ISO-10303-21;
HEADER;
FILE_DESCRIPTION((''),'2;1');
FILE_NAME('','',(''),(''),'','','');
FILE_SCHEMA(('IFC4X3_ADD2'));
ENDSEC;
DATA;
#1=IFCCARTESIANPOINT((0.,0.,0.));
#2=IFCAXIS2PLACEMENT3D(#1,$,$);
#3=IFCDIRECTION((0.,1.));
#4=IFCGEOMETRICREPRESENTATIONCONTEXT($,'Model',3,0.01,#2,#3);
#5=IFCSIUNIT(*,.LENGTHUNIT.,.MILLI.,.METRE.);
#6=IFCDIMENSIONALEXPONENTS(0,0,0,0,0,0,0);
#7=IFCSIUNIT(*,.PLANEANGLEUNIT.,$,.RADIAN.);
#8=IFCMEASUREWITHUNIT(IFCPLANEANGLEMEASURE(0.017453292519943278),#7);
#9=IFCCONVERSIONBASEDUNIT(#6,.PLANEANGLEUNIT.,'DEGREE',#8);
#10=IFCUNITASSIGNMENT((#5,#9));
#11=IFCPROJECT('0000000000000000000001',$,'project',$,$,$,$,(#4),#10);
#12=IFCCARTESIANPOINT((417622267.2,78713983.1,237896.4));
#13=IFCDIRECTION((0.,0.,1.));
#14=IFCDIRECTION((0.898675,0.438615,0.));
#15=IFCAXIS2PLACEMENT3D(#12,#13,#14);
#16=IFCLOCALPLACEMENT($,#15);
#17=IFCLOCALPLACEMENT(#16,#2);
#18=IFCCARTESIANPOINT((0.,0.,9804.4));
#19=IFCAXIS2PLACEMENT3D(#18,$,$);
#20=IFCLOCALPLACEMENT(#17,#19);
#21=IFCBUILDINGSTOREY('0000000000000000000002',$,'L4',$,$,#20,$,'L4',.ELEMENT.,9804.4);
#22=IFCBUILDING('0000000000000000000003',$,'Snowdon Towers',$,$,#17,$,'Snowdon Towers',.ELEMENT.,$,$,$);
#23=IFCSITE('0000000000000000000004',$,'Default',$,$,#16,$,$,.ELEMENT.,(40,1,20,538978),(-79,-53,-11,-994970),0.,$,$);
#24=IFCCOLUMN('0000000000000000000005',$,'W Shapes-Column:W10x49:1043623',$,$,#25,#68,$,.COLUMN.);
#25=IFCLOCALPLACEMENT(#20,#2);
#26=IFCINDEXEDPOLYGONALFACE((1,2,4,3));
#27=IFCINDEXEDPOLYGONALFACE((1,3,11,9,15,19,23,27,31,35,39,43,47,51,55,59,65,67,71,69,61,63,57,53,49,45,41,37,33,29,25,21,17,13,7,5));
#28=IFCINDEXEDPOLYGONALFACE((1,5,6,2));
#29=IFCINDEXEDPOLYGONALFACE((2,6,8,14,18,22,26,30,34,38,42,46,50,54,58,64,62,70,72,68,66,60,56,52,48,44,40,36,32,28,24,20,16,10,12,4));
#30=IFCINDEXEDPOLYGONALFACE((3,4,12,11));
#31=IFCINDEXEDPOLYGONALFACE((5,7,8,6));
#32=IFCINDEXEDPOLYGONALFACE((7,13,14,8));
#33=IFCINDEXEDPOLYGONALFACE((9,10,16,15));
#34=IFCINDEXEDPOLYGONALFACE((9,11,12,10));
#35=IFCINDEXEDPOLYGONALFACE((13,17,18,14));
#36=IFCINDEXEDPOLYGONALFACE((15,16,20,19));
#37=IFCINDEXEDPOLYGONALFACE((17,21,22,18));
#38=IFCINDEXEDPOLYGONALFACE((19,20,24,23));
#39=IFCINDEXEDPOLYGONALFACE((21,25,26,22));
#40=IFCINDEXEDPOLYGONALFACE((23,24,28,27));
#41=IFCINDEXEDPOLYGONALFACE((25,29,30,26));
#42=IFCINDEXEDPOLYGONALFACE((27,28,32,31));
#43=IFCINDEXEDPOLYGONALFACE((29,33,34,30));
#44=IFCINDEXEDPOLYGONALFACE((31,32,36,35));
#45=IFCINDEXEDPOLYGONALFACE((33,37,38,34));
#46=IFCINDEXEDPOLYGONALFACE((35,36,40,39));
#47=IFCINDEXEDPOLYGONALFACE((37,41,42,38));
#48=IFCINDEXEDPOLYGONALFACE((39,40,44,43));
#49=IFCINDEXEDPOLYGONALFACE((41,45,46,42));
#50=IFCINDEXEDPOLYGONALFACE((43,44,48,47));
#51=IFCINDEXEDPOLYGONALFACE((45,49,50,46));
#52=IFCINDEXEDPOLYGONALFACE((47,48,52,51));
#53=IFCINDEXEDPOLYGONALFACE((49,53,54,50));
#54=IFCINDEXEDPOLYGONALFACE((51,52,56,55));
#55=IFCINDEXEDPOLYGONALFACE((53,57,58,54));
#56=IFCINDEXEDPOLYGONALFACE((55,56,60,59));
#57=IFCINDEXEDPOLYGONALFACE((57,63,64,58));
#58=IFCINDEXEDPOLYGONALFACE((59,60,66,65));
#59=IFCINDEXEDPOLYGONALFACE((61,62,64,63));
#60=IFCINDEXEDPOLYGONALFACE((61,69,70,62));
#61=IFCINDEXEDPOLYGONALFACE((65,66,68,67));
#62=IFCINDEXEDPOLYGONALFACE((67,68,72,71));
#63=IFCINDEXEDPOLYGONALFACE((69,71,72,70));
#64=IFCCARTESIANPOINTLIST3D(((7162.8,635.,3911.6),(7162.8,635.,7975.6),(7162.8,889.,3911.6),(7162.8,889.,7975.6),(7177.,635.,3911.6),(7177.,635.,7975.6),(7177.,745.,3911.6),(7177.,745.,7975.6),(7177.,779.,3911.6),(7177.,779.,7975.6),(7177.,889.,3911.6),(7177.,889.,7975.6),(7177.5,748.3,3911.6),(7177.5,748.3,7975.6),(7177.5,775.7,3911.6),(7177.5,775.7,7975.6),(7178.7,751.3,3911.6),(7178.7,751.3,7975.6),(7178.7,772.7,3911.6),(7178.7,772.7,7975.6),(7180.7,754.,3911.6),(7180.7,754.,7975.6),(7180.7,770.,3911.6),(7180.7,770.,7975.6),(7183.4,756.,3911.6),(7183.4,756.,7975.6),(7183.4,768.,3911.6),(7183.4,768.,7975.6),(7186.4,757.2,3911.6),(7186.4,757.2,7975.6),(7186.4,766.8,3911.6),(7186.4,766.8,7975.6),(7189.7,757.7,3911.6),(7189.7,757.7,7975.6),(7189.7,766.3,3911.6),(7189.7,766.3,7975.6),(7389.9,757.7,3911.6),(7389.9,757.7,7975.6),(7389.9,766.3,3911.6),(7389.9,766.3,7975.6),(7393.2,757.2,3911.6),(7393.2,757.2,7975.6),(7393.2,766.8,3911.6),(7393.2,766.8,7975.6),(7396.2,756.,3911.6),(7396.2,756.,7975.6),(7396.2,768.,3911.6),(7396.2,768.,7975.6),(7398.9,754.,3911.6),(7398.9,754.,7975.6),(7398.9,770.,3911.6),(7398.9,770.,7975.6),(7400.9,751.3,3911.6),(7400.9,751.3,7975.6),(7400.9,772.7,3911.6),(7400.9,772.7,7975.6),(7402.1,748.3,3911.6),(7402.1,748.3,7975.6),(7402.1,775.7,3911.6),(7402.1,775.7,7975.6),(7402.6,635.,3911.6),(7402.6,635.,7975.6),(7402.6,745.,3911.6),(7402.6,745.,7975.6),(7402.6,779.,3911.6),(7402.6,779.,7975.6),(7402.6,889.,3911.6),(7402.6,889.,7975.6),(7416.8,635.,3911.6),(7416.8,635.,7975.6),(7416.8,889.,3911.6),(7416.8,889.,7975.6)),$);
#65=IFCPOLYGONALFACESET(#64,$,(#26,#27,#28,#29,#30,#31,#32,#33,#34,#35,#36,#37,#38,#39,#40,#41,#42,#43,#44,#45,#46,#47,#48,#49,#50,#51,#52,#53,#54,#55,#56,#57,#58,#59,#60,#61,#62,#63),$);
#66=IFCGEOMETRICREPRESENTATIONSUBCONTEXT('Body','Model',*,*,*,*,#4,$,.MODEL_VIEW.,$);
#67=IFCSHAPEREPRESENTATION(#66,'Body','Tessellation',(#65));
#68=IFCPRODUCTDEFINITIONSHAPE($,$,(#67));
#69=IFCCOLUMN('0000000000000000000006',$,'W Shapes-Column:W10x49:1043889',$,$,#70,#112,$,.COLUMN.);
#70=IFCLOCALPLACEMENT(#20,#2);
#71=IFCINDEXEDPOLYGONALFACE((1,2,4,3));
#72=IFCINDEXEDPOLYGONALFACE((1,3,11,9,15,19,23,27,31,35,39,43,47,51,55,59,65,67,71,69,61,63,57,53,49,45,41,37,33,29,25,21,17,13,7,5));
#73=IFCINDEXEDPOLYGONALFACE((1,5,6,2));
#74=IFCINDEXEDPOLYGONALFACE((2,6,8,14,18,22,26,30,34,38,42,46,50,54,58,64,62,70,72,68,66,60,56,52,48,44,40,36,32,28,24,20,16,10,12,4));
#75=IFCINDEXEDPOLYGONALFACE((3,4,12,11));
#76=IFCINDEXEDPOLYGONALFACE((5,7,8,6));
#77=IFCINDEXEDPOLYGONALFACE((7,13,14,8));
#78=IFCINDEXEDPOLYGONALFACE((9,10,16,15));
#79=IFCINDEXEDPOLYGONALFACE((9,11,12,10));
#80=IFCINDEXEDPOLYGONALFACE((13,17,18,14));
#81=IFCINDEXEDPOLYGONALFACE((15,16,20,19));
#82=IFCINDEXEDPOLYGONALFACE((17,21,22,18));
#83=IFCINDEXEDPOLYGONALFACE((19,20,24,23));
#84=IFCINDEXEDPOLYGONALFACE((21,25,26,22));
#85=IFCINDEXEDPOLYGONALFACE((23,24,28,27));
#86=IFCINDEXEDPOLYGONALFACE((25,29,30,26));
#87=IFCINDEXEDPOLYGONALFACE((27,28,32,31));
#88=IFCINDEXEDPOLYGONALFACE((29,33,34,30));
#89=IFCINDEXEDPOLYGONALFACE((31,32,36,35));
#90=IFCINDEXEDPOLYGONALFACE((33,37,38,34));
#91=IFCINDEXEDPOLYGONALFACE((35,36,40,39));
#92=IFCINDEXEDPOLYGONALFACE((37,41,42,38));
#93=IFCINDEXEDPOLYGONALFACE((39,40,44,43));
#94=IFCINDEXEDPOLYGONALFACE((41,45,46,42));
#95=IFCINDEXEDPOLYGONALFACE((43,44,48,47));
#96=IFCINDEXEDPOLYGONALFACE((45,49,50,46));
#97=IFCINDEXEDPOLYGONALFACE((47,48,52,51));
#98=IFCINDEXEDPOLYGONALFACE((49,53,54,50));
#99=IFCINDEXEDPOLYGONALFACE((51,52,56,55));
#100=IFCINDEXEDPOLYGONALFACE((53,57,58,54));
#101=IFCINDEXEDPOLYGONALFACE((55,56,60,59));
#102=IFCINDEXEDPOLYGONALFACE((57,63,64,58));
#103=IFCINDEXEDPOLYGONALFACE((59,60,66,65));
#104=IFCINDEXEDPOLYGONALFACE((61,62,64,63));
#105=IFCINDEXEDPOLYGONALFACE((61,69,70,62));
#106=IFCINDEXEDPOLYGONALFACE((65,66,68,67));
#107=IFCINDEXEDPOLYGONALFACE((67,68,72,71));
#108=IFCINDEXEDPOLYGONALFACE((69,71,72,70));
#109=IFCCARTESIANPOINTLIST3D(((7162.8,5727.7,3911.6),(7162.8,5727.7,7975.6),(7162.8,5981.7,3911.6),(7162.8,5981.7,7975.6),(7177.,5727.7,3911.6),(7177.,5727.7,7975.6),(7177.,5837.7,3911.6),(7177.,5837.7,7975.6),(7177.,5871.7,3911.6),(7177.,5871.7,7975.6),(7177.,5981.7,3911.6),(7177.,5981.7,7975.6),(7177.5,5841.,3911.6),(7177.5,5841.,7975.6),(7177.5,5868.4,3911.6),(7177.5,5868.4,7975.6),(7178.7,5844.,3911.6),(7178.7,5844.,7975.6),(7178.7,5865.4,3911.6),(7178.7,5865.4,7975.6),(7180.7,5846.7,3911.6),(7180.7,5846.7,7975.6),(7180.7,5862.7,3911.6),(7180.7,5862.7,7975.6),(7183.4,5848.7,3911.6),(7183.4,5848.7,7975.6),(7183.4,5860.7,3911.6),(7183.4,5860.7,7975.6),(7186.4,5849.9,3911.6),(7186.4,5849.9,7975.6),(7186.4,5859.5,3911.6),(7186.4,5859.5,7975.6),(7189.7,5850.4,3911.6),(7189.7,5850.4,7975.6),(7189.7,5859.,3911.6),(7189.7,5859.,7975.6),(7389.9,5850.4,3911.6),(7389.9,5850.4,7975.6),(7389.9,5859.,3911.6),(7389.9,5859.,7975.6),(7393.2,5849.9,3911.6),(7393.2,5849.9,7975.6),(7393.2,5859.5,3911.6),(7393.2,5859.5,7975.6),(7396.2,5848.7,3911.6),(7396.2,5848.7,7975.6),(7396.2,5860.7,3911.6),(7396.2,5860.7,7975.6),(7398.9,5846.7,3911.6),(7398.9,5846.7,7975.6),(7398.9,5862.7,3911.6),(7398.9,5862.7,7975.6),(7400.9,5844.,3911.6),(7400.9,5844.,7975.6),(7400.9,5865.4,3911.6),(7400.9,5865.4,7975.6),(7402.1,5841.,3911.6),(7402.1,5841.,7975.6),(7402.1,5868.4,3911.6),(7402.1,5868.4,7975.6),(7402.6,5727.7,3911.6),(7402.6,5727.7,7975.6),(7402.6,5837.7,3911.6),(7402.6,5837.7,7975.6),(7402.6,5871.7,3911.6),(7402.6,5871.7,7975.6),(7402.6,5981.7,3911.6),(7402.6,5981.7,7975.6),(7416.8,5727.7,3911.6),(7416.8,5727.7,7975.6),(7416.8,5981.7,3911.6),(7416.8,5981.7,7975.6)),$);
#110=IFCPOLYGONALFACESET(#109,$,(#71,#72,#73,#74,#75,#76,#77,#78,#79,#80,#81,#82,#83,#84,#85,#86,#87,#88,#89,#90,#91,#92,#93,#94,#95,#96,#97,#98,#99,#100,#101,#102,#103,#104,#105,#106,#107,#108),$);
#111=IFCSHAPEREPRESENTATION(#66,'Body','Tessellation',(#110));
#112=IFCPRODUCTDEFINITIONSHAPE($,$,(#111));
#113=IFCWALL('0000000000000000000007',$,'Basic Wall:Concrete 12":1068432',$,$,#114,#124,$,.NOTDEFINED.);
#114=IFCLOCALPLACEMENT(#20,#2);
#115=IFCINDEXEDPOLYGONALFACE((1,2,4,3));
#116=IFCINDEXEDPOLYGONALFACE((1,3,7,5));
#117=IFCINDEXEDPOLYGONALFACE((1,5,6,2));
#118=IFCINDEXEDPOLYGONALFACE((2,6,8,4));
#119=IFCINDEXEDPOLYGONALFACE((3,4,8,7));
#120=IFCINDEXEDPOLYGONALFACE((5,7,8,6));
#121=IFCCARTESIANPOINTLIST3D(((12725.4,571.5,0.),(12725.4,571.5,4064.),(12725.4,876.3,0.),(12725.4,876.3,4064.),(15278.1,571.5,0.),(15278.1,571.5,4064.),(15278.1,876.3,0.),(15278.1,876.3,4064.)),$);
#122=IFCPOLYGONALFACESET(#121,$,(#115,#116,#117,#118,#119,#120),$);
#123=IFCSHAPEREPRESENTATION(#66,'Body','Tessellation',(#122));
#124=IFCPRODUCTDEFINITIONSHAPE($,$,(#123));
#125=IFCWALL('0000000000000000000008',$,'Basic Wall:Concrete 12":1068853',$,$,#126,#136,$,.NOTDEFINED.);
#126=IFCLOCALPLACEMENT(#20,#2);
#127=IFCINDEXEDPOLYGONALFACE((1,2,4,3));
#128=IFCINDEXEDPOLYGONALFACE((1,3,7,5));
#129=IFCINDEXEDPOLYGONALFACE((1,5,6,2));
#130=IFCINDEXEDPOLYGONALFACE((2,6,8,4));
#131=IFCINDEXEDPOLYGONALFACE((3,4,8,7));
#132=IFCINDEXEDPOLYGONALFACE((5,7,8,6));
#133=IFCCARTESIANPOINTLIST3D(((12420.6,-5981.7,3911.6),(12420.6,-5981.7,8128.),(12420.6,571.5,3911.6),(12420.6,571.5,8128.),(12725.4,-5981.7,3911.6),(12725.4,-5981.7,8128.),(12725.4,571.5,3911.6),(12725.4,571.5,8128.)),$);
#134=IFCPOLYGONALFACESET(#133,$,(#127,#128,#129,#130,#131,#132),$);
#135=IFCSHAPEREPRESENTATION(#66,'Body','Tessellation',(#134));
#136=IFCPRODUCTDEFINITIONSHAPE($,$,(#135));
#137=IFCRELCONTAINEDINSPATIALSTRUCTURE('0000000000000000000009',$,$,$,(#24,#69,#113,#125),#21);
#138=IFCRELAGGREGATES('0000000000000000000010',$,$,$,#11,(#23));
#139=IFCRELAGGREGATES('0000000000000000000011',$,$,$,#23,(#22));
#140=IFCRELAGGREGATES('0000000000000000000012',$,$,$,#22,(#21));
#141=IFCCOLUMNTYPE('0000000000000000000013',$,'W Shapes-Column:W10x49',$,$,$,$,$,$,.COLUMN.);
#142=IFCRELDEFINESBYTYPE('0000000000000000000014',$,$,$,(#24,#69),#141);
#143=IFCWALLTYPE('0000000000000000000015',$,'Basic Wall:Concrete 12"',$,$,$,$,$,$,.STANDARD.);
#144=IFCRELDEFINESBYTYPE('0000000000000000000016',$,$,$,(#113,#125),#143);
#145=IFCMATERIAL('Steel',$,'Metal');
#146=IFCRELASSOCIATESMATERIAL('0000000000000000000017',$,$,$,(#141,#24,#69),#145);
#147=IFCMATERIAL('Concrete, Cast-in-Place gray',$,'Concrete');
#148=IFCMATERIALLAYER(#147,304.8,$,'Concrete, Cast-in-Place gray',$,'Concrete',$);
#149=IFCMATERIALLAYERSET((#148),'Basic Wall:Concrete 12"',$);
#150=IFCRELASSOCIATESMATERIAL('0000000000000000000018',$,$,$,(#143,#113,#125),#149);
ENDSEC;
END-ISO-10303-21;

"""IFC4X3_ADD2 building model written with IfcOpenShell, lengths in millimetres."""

from ifc_helpers import new_model, entity, si_unit, converted_unit, direction, frame, frame_2d, origin, place, context, subcontext, project, spatial, rectangle, i_section, extrude, source, transform, mapped, material, layer, layer_set, material_profile, profile_set, profile_usage, type_object, type_shapes, element, save


model = new_model("IFC4X3_ADD2")

# Units and contexts
model_context = context("Model", 3, precision=0.01, world=origin(), true_north=direction((0.0, 1.0)))
body_context = subcontext(model_context, "Body", "Model", "MODEL_VIEW")
ifc_project = project(units=[si_unit("LENGTHUNIT", "METRE", prefix="MILLI"), converted_unit("PLANEANGLEUNIT", "DEGREE", entity("IfcPlaneAngleMeasure", 0.017453292519943278), si_unit("PLANEANGLEUNIT", "RADIAN"), dimensions=[0, 0, 0, 0, 0, 0, 0])], contexts=[model_context])

# Site, building, storey
site_placement = place(None, frame((417622267.2, 78713983.1, 237896.4), z_axis=(0.0, 0.0, 1.0), x_axis=(0.898675, 0.438615, 0.0)))
site = spatial("IfcSite", under=ifc_project, at=site_placement, Name="Default", CompositionType="ELEMENT", RefLatitude=(40, 1, 20, 538978), RefLongitude=(-79, -53, -11, -994970), RefElevation=0.0)
building_placement = place(site_placement, origin())
building = spatial("IfcBuilding", under=site, at=building_placement, Name="Snowdon Towers", LongName="Snowdon Towers", CompositionType="ELEMENT")
storey_placement = place(building_placement, frame((0.0, 0.0, 9804.4)))
storey = spatial("IfcBuildingStorey", under=building, at=storey_placement, Name="L4", LongName="L4", CompositionType="ELEMENT", Elevation=9804.4)

# Columns
ifc_material_1 = material(Name="Steel", Category="Metal")
ifc_material_profile_1 = material_profile(ifc_material_1, i_section(OverallWidth=254.0, OverallDepth=254.0, WebThickness=8.6, FlangeThickness=14.2, FilletRadius=12.7, at=frame_2d((0.0, 0.0), x_axis=(1.0, 0.0))), Name="W10x49")
ifc_profile_set_1 = profile_set([ifc_material_profile_1], Name="W10x49")
ifc_profile_usage_1 = profile_usage(ifc_profile_set_1)
column_type_1 = type_object("IfcColumnType", Name="W Shapes-Column:W10x49", PredefinedType="COLUMN", material=ifc_profile_set_1)
shared_shape_1 = source(origin(), body_context, "Body", "SweptSolid", [
    extrude(i_section(OverallWidth=254.0, OverallDepth=254.0, WebThickness=8.6, FlangeThickness=14.2, FilletRadius=12.7, at=frame_2d((0.0, 0.0), x_axis=(1.0, 0.0))), frame((0.0, 0.0, 13716.0), z_axis=(0.0, 0.0, 1.0), x_axis=(-1.0, 0.0, 0.0)), (0.0, 0.0, 1.0), 4064.0),
])
type_shapes(column_type_1, [shared_shape_1])
for number, where, z_axis, x_axis, name in (
    (1, (7289.8, 762.0, -9804.4), (0.0, 0.0, 1.0), (0.0, 1.0, 0.0), "W Shapes-Column:W10x49:1043623"),
    (2, (7289.8, 5854.7, -9804.4), (0.0, 0.0, 1.0), (0.0, 1.0, 0.0), "W Shapes-Column:W10x49:1043889"),
):
    element("IfcColumn", number, at=place(storey_placement, frame(where, z_axis=z_axis, x_axis=x_axis)), inside=storey, type_object=column_type_1, material=ifc_profile_usage_1, Name=name, PredefinedType="COLUMN", context=body_context, shape_type="MappedRepresentation", body=[
        mapped(shared_shape_1, transform((0.0, 0.0, 0.0), scale=1.0)),
    ])

# Walls
ifc_material_2 = material(Name="Concrete, Cast-in-Place gray", Category="Concrete")
ifc_layer = layer(ifc_material_2, 304.8, Name="Concrete, Cast-in-Place gray", Category="Concrete")
ifc_layer_set = layer_set([ifc_layer], Name="Basic Wall:Concrete 12\"")
wall_type = type_object("IfcWallType", Name="Basic Wall:Concrete 12\"", PredefinedType="STANDARD", material=ifc_layer_set)
wall_1_placement = place(storey_placement, frame((15278.1, 723.9, 0.0), z_axis=(0.0, 0.0, 1.0), x_axis=(-1.0, 0.0, 0.0)))
element("IfcWall", 3, at=wall_1_placement, inside=storey, type_object=wall_type, material=ifc_layer_set, Name="Basic Wall:Concrete 12\":1068432", PredefinedType="NOTDEFINED", context=body_context, shape_type="SweptSolid", body=[
    extrude(rectangle(XDim=2552.7, YDim=304.8, at=frame_2d((1276.3, 0.0), x_axis=(-1.0, 0.0))), origin(), (0.0, 0.0, 1.0), 4064.0),
])
wall_2_placement = place(storey_placement, frame((12573.0, 571.5, 3911.6), z_axis=(0.0, 0.0, 1.0), x_axis=(0.0, -1.0, 0.0)))
element("IfcWall", 4, at=wall_2_placement, inside=storey, type_object=wall_type, material=ifc_layer_set, Name="Basic Wall:Concrete 12\":1068853", PredefinedType="NOTDEFINED", context=body_context, shape_type="SweptSolid", body=[
    extrude(rectangle(XDim=6553.2, YDim=304.8, at=frame_2d((3276.6, 0.0), x_axis=(-1.0, 0.0))), origin(), (0.0, 0.0, 1.0), 4216.4),
])

save(model, "model.ifc")
